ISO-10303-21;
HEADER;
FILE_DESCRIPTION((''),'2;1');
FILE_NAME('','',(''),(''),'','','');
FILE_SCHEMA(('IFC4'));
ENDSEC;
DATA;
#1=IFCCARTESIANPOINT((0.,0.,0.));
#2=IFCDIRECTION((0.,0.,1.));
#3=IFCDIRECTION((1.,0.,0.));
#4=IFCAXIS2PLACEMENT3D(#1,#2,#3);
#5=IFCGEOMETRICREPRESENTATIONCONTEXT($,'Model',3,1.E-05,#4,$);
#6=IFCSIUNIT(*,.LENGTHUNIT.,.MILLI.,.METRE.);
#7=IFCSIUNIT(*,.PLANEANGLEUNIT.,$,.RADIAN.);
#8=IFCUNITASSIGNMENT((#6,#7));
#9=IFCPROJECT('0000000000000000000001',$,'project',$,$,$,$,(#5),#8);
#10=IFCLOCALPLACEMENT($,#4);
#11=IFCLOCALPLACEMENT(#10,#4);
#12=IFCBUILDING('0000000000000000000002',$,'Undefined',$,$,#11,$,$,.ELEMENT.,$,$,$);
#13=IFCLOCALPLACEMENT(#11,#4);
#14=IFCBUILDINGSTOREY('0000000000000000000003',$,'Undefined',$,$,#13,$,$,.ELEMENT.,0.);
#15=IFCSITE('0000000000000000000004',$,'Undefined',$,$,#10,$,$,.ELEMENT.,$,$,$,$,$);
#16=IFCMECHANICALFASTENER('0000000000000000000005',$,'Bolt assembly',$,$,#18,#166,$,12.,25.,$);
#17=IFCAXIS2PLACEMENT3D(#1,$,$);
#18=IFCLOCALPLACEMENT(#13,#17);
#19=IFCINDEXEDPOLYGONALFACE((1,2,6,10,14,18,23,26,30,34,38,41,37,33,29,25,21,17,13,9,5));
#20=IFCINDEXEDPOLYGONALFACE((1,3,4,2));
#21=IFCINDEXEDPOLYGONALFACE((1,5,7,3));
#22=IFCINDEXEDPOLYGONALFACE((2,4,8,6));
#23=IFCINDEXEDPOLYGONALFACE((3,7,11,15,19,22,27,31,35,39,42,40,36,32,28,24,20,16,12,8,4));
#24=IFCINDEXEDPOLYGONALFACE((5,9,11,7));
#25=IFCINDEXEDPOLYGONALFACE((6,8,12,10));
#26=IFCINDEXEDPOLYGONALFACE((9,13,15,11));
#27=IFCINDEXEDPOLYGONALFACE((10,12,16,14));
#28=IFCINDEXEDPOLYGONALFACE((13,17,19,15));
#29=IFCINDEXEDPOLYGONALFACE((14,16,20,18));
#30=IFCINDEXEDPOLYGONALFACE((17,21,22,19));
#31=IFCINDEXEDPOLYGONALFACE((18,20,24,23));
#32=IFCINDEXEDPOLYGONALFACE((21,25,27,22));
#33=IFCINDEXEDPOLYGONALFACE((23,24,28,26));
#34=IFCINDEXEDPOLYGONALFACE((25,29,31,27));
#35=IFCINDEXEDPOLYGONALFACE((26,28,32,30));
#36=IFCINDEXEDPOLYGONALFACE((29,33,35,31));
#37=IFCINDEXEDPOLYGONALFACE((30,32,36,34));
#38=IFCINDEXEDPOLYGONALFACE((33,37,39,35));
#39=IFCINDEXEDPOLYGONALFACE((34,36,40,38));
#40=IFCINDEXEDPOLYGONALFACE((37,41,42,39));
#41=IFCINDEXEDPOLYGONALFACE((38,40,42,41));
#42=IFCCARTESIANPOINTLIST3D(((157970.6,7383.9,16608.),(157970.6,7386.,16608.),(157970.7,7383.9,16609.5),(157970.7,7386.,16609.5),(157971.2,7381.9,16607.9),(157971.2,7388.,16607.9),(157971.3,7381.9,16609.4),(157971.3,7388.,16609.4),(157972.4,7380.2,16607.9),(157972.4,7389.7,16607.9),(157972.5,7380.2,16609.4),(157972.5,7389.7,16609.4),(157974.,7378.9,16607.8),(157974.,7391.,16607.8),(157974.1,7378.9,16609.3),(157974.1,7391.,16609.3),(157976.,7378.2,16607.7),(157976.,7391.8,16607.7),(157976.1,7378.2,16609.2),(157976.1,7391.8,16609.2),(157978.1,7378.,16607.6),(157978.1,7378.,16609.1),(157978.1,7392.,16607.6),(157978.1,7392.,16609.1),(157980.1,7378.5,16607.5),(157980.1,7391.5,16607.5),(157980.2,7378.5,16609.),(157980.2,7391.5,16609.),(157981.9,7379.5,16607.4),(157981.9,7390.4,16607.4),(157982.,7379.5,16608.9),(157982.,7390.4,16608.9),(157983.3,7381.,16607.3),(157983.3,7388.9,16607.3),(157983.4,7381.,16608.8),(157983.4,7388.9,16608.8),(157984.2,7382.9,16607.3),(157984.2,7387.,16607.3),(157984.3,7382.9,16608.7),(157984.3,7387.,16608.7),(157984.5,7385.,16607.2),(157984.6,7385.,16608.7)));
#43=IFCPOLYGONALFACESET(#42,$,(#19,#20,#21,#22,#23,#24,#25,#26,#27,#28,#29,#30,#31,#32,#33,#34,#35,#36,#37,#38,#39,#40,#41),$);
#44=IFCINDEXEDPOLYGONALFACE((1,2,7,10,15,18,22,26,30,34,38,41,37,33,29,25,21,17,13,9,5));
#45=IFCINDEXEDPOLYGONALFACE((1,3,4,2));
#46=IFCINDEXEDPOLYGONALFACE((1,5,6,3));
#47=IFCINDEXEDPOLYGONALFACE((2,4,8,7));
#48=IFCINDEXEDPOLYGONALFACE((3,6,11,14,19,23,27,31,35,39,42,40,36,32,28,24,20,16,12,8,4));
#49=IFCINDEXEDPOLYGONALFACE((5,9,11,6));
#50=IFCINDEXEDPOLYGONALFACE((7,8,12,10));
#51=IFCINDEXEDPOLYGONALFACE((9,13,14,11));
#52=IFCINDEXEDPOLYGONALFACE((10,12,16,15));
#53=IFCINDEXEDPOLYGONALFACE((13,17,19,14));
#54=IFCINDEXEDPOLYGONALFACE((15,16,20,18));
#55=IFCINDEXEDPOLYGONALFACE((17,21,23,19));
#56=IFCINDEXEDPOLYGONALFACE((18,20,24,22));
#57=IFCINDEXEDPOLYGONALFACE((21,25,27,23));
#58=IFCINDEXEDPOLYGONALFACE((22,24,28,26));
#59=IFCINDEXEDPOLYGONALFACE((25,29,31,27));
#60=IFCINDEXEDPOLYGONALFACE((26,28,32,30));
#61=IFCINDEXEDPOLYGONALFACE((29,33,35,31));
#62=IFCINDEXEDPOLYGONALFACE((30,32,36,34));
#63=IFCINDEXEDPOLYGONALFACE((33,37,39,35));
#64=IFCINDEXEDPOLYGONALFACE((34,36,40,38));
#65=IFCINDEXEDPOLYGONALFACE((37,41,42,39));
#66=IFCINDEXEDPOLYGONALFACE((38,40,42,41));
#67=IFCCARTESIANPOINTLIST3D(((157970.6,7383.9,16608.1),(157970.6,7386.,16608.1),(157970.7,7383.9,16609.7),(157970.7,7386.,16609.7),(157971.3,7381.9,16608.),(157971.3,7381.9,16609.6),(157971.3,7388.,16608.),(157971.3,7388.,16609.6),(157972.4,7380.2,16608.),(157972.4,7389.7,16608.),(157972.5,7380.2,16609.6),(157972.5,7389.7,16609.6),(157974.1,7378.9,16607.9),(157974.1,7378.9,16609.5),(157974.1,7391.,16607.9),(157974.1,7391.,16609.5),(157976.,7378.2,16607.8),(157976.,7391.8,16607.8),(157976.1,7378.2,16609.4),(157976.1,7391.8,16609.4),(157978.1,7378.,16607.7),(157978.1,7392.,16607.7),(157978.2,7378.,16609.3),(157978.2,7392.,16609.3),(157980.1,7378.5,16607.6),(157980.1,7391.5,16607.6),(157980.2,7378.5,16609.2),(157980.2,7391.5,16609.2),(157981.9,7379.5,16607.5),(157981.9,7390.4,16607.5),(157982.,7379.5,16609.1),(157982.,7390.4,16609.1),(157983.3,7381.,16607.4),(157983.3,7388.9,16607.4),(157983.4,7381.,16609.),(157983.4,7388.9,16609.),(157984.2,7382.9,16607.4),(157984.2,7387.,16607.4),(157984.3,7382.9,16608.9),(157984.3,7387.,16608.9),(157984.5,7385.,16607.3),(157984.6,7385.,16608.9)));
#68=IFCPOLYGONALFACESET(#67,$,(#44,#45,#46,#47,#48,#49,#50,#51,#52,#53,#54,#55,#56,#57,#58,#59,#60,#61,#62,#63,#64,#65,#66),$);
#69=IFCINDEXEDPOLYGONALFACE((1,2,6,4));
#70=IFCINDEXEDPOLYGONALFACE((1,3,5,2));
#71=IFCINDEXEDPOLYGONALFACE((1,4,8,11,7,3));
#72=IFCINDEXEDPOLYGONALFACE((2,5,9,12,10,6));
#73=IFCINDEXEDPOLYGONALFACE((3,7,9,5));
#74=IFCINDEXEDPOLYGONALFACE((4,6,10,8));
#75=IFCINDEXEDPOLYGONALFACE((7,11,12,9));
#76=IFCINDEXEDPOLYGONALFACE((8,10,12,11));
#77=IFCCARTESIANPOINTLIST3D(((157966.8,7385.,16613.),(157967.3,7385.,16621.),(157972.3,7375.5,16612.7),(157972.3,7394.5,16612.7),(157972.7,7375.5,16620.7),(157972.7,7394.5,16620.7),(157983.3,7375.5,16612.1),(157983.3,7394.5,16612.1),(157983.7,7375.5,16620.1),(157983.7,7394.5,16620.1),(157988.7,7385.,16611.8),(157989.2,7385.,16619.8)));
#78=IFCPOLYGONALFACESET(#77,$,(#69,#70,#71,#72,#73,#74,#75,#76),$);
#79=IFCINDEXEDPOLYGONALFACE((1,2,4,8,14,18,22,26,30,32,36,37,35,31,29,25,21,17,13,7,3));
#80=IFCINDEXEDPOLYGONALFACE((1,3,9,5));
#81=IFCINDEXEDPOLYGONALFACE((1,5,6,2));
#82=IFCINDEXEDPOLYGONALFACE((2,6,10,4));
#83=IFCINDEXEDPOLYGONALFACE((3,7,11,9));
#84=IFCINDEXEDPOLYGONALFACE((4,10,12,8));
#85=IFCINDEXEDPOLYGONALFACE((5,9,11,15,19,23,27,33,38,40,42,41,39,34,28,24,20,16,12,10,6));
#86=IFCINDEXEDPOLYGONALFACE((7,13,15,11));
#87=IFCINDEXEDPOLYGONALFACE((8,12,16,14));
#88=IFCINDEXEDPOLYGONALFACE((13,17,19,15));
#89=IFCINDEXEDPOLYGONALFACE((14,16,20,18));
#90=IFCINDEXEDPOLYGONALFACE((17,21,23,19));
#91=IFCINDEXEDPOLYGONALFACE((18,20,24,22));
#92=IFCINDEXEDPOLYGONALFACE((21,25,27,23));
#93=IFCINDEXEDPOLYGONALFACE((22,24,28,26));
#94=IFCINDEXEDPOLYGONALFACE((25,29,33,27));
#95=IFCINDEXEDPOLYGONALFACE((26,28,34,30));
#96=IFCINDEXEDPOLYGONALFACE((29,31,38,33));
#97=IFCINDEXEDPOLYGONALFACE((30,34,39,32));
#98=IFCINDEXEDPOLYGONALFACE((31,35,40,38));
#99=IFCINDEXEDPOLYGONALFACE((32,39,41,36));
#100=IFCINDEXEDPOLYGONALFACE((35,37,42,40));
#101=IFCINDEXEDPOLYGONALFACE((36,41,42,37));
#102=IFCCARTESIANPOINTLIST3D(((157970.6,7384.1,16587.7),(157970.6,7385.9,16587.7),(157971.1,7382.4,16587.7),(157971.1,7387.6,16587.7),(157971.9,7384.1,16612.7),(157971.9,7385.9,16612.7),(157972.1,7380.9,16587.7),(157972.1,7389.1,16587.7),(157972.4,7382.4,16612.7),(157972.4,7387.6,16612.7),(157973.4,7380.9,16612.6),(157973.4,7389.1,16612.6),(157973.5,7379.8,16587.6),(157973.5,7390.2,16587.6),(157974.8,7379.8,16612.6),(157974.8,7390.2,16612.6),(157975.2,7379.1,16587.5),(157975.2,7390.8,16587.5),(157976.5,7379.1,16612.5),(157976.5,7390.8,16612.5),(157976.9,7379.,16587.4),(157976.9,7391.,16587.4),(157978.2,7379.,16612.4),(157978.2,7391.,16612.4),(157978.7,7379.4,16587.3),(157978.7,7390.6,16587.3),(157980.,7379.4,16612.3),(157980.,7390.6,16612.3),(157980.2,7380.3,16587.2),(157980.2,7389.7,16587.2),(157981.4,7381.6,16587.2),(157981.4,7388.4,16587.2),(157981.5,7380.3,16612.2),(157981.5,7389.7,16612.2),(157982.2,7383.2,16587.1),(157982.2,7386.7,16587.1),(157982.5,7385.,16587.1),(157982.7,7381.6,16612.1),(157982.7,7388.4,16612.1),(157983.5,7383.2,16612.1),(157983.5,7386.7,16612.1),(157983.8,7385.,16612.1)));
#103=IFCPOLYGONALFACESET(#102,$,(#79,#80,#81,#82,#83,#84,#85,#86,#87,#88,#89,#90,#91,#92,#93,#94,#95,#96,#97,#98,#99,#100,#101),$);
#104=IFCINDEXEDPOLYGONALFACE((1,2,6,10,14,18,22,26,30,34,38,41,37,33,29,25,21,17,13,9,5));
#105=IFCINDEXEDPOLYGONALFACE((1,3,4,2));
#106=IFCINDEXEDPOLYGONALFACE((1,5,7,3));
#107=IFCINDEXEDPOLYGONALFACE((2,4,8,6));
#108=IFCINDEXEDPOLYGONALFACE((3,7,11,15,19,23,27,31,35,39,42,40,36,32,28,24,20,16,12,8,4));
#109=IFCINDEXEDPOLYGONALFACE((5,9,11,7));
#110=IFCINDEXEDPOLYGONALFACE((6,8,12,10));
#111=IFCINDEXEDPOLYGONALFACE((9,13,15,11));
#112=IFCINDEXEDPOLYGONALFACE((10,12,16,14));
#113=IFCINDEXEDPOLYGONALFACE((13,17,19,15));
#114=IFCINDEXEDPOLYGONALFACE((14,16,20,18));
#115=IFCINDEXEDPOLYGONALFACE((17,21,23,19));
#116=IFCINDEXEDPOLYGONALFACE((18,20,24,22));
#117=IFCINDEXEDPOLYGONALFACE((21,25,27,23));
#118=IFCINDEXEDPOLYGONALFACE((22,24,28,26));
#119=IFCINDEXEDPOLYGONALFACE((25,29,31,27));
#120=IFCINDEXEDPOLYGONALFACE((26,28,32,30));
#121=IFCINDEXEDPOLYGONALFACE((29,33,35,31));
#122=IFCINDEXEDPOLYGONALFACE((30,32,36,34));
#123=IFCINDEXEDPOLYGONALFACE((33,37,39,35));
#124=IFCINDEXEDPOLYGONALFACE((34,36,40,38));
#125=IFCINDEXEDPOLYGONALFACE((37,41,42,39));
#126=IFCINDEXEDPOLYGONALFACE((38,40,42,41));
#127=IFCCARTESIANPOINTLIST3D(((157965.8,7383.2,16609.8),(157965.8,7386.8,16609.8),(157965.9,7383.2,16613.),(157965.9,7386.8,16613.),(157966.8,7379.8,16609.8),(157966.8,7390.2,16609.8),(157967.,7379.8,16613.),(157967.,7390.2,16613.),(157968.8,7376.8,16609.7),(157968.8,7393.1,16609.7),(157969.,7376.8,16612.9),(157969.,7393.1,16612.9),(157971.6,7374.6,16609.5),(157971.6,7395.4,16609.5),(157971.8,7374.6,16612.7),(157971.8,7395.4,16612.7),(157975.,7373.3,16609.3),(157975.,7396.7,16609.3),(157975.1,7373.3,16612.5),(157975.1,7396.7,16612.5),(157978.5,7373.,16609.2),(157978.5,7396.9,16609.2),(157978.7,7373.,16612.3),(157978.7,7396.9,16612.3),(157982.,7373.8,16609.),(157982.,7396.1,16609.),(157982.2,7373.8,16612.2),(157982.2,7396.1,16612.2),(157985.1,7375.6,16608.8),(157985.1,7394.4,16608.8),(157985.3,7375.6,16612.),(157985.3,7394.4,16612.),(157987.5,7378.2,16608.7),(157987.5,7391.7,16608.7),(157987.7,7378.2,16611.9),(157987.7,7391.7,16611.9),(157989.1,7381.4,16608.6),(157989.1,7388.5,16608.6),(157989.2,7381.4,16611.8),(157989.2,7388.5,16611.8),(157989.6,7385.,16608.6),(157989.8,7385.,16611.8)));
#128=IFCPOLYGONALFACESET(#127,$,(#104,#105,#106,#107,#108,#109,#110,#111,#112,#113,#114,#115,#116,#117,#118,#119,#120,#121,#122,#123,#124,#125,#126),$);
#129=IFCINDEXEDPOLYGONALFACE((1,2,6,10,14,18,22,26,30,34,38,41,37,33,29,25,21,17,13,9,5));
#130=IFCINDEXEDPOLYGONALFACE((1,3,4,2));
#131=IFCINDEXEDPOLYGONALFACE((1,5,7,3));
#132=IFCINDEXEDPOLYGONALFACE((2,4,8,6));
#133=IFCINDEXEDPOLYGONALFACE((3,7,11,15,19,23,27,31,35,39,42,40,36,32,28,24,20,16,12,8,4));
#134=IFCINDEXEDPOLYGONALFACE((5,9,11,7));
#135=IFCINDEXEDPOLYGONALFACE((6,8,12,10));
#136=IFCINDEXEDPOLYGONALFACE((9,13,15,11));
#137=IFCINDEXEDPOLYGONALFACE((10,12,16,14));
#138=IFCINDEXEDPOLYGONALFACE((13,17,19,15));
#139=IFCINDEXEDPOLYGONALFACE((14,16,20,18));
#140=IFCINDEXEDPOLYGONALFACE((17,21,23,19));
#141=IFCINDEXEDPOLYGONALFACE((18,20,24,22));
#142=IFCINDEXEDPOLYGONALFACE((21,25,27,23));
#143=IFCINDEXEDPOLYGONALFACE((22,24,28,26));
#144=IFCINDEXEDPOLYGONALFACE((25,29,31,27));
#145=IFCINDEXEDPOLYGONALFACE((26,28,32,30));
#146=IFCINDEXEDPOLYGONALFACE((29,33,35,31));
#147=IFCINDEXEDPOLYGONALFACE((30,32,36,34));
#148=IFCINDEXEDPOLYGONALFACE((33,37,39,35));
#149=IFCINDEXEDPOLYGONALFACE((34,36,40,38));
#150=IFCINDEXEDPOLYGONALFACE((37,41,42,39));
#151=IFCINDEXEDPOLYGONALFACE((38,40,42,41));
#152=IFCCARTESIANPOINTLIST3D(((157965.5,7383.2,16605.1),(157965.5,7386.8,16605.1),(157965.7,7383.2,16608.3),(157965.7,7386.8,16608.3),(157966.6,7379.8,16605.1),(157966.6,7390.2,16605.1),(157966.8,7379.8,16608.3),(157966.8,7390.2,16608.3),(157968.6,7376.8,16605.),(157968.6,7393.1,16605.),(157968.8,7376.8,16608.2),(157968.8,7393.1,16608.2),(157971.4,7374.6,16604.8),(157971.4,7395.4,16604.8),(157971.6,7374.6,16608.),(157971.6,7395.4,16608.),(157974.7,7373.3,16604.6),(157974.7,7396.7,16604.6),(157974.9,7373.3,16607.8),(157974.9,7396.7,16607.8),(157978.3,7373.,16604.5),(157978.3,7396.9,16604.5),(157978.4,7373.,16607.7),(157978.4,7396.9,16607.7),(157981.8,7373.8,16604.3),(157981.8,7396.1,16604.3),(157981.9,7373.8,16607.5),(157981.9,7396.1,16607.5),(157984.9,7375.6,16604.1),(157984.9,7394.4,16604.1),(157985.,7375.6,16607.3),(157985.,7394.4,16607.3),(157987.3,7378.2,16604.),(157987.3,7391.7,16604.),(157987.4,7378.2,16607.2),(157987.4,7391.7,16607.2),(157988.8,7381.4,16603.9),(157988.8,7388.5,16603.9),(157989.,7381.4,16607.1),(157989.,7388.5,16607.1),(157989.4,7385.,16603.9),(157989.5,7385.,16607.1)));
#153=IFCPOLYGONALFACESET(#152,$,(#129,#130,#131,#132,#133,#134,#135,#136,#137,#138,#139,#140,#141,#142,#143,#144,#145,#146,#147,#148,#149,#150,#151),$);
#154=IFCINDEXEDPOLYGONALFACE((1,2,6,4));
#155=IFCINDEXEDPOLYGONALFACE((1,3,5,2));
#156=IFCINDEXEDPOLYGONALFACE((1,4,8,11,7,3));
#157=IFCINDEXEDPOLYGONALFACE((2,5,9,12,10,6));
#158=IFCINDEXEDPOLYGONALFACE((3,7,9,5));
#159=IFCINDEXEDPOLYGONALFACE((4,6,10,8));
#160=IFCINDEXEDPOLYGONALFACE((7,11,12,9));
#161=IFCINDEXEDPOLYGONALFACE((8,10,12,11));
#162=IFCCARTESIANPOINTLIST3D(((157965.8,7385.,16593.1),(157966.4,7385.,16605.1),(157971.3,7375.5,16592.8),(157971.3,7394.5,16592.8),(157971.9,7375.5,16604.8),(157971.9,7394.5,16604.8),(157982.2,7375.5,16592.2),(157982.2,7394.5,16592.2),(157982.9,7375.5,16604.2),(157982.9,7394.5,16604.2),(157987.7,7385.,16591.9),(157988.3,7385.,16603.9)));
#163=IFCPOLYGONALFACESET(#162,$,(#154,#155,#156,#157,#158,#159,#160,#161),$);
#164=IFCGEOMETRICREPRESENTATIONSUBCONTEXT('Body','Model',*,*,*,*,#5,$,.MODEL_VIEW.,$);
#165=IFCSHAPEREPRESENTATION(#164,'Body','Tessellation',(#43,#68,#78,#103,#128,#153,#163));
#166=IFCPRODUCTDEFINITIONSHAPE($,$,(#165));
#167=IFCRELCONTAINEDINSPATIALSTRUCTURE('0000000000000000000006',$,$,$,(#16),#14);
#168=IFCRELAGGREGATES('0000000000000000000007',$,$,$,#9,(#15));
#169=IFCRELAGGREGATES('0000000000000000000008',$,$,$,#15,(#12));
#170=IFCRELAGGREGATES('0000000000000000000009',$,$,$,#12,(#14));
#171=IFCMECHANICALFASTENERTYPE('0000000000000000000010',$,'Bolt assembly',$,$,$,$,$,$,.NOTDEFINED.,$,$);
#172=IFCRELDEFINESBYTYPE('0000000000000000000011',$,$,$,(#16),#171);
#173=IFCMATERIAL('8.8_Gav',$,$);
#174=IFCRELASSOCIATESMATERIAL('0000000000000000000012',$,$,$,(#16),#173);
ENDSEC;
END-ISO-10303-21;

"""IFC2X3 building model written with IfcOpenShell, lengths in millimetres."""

from ifc_helpers import new_model, si_unit, frame, origin_with_axes, origin_2d_with_axis, place, context, subcontext, project, spatial, polyline, circle, outline, extrude, source, transform, mapped, material, type_object, element, save


model = new_model("IFC2X3")

# Units and contexts
model_context = context("Model", 3, precision=1e-05, world=origin_with_axes())
body_context = subcontext(model_context, "Body", "Model", "MODEL_VIEW")
ifc_project = project(units=[si_unit("LENGTHUNIT", "METRE", prefix="MILLI"), si_unit("PLANEANGLEUNIT", "RADIAN")], contexts=[model_context])

# Site, building, storey
site_placement = place(None, origin_with_axes())
site = spatial("IfcSite", under=ifc_project, at=site_placement, Name="Undefined", CompositionType="ELEMENT")
building_placement = place(site_placement, origin_with_axes())
building = spatial("IfcBuilding", under=site, at=building_placement, Name="Undefined", CompositionType="ELEMENT")
storey_placement = place(building_placement, origin_with_axes())
storey = spatial("IfcBuildingStorey", under=building, at=storey_placement, Name="Undefined", CompositionType="ELEMENT", Elevation=0.0)

# Mechanical fastener
mechanical_fastener_type = type_object("IfcMechanicalFastenerType", Name="Bolt assembly")
ifc_material_1 = material(Name="8.8_Gav")
shared_shape_1 = source(origin_with_axes(), body_context, "Body", "SweptSolid", [
    extrude(circle(Radius=7.0, at=origin_2d_with_axis()), frame((0.0, -0.4, 0.0), z_axis=(0.0, 1.0, 0.0), x_axis=(1.0, 0.0, 0.0)), (0.0, 0.0, 1.0), 1.5),
    extrude(circle(Radius=7.0, at=origin_2d_with_axis()), frame((0.0, -0.6, 0.0), z_axis=(0.0, 1.0, 0.0), x_axis=(1.0, 0.0, 0.0)), (0.0, 0.0, 1.0), 1.6),
    extrude(outline(polyline([(11.0, 0.0), (5.5, 9.5), (-5.5, 9.5), (-11.0, 0.0), (-5.5, -9.5), (5.5, -9.5), (11.0, 0.0)])), frame((0.0, -11.7, 0.0), z_axis=(0.0, 1.0, 0.0), x_axis=(1.0, 0.0, 0.0)), (0.0, 0.0, 1.0), 8.0),
    extrude(circle(Radius=6.0, at=origin_2d_with_axis()), frame((0.0, -3.7, 0.0), z_axis=(0.0, 1.0, 0.0), x_axis=(1.0, 0.0, 0.0)), (0.0, 0.0, 1.0), 25.0),
    extrude(circle(Radius=12.0, at=origin_2d_with_axis()), frame((0.0, -3.7, 0.0), z_axis=(0.0, 1.0, 0.0), x_axis=(1.0, 0.0, 0.0)), (0.0, 0.0, 1.0), 3.2),
    extrude(circle(Radius=12.0, at=origin_2d_with_axis()), frame((0.0, 1.0, 0.0), z_axis=(0.0, 1.0, 0.0), x_axis=(1.0, 0.0, 0.0)), (0.0, 0.0, 1.0), 3.2),
    extrude(outline(polyline([(11.0, 0.0), (5.5, 9.5), (-5.5, 9.5), (-11.0, 0.0), (-5.5, -9.5), (5.5, -9.5), (11.0, 0.0)])), frame((0.0, 4.2, 0.0), z_axis=(0.0, 1.0, 0.0), x_axis=(1.0, 0.0, 0.0)), (0.0, 0.0, 1.0), 12.0),
])
for number, where, z_axis, x_axis, name in (
    (1, (157977.6, 7385.0, 16608.7), (0.0, 1.0, 0.0), (0.998627, 0.0, -0.052392), "Bolt assembly"),
):
    element("IfcMechanicalFastener", number, at=place(storey_placement, frame(where, z_axis=z_axis, x_axis=x_axis)), inside=storey, type_object=mechanical_fastener_type, material=ifc_material_1, Name=name, NominalDiameter=12.0, NominalLength=25.0, context=body_context, shape_type="MappedRepresentation", body=[
        mapped(shared_shape_1, transform((0.0, 0.0, 0.0))),
    ])

save(model, "model.ifc")
